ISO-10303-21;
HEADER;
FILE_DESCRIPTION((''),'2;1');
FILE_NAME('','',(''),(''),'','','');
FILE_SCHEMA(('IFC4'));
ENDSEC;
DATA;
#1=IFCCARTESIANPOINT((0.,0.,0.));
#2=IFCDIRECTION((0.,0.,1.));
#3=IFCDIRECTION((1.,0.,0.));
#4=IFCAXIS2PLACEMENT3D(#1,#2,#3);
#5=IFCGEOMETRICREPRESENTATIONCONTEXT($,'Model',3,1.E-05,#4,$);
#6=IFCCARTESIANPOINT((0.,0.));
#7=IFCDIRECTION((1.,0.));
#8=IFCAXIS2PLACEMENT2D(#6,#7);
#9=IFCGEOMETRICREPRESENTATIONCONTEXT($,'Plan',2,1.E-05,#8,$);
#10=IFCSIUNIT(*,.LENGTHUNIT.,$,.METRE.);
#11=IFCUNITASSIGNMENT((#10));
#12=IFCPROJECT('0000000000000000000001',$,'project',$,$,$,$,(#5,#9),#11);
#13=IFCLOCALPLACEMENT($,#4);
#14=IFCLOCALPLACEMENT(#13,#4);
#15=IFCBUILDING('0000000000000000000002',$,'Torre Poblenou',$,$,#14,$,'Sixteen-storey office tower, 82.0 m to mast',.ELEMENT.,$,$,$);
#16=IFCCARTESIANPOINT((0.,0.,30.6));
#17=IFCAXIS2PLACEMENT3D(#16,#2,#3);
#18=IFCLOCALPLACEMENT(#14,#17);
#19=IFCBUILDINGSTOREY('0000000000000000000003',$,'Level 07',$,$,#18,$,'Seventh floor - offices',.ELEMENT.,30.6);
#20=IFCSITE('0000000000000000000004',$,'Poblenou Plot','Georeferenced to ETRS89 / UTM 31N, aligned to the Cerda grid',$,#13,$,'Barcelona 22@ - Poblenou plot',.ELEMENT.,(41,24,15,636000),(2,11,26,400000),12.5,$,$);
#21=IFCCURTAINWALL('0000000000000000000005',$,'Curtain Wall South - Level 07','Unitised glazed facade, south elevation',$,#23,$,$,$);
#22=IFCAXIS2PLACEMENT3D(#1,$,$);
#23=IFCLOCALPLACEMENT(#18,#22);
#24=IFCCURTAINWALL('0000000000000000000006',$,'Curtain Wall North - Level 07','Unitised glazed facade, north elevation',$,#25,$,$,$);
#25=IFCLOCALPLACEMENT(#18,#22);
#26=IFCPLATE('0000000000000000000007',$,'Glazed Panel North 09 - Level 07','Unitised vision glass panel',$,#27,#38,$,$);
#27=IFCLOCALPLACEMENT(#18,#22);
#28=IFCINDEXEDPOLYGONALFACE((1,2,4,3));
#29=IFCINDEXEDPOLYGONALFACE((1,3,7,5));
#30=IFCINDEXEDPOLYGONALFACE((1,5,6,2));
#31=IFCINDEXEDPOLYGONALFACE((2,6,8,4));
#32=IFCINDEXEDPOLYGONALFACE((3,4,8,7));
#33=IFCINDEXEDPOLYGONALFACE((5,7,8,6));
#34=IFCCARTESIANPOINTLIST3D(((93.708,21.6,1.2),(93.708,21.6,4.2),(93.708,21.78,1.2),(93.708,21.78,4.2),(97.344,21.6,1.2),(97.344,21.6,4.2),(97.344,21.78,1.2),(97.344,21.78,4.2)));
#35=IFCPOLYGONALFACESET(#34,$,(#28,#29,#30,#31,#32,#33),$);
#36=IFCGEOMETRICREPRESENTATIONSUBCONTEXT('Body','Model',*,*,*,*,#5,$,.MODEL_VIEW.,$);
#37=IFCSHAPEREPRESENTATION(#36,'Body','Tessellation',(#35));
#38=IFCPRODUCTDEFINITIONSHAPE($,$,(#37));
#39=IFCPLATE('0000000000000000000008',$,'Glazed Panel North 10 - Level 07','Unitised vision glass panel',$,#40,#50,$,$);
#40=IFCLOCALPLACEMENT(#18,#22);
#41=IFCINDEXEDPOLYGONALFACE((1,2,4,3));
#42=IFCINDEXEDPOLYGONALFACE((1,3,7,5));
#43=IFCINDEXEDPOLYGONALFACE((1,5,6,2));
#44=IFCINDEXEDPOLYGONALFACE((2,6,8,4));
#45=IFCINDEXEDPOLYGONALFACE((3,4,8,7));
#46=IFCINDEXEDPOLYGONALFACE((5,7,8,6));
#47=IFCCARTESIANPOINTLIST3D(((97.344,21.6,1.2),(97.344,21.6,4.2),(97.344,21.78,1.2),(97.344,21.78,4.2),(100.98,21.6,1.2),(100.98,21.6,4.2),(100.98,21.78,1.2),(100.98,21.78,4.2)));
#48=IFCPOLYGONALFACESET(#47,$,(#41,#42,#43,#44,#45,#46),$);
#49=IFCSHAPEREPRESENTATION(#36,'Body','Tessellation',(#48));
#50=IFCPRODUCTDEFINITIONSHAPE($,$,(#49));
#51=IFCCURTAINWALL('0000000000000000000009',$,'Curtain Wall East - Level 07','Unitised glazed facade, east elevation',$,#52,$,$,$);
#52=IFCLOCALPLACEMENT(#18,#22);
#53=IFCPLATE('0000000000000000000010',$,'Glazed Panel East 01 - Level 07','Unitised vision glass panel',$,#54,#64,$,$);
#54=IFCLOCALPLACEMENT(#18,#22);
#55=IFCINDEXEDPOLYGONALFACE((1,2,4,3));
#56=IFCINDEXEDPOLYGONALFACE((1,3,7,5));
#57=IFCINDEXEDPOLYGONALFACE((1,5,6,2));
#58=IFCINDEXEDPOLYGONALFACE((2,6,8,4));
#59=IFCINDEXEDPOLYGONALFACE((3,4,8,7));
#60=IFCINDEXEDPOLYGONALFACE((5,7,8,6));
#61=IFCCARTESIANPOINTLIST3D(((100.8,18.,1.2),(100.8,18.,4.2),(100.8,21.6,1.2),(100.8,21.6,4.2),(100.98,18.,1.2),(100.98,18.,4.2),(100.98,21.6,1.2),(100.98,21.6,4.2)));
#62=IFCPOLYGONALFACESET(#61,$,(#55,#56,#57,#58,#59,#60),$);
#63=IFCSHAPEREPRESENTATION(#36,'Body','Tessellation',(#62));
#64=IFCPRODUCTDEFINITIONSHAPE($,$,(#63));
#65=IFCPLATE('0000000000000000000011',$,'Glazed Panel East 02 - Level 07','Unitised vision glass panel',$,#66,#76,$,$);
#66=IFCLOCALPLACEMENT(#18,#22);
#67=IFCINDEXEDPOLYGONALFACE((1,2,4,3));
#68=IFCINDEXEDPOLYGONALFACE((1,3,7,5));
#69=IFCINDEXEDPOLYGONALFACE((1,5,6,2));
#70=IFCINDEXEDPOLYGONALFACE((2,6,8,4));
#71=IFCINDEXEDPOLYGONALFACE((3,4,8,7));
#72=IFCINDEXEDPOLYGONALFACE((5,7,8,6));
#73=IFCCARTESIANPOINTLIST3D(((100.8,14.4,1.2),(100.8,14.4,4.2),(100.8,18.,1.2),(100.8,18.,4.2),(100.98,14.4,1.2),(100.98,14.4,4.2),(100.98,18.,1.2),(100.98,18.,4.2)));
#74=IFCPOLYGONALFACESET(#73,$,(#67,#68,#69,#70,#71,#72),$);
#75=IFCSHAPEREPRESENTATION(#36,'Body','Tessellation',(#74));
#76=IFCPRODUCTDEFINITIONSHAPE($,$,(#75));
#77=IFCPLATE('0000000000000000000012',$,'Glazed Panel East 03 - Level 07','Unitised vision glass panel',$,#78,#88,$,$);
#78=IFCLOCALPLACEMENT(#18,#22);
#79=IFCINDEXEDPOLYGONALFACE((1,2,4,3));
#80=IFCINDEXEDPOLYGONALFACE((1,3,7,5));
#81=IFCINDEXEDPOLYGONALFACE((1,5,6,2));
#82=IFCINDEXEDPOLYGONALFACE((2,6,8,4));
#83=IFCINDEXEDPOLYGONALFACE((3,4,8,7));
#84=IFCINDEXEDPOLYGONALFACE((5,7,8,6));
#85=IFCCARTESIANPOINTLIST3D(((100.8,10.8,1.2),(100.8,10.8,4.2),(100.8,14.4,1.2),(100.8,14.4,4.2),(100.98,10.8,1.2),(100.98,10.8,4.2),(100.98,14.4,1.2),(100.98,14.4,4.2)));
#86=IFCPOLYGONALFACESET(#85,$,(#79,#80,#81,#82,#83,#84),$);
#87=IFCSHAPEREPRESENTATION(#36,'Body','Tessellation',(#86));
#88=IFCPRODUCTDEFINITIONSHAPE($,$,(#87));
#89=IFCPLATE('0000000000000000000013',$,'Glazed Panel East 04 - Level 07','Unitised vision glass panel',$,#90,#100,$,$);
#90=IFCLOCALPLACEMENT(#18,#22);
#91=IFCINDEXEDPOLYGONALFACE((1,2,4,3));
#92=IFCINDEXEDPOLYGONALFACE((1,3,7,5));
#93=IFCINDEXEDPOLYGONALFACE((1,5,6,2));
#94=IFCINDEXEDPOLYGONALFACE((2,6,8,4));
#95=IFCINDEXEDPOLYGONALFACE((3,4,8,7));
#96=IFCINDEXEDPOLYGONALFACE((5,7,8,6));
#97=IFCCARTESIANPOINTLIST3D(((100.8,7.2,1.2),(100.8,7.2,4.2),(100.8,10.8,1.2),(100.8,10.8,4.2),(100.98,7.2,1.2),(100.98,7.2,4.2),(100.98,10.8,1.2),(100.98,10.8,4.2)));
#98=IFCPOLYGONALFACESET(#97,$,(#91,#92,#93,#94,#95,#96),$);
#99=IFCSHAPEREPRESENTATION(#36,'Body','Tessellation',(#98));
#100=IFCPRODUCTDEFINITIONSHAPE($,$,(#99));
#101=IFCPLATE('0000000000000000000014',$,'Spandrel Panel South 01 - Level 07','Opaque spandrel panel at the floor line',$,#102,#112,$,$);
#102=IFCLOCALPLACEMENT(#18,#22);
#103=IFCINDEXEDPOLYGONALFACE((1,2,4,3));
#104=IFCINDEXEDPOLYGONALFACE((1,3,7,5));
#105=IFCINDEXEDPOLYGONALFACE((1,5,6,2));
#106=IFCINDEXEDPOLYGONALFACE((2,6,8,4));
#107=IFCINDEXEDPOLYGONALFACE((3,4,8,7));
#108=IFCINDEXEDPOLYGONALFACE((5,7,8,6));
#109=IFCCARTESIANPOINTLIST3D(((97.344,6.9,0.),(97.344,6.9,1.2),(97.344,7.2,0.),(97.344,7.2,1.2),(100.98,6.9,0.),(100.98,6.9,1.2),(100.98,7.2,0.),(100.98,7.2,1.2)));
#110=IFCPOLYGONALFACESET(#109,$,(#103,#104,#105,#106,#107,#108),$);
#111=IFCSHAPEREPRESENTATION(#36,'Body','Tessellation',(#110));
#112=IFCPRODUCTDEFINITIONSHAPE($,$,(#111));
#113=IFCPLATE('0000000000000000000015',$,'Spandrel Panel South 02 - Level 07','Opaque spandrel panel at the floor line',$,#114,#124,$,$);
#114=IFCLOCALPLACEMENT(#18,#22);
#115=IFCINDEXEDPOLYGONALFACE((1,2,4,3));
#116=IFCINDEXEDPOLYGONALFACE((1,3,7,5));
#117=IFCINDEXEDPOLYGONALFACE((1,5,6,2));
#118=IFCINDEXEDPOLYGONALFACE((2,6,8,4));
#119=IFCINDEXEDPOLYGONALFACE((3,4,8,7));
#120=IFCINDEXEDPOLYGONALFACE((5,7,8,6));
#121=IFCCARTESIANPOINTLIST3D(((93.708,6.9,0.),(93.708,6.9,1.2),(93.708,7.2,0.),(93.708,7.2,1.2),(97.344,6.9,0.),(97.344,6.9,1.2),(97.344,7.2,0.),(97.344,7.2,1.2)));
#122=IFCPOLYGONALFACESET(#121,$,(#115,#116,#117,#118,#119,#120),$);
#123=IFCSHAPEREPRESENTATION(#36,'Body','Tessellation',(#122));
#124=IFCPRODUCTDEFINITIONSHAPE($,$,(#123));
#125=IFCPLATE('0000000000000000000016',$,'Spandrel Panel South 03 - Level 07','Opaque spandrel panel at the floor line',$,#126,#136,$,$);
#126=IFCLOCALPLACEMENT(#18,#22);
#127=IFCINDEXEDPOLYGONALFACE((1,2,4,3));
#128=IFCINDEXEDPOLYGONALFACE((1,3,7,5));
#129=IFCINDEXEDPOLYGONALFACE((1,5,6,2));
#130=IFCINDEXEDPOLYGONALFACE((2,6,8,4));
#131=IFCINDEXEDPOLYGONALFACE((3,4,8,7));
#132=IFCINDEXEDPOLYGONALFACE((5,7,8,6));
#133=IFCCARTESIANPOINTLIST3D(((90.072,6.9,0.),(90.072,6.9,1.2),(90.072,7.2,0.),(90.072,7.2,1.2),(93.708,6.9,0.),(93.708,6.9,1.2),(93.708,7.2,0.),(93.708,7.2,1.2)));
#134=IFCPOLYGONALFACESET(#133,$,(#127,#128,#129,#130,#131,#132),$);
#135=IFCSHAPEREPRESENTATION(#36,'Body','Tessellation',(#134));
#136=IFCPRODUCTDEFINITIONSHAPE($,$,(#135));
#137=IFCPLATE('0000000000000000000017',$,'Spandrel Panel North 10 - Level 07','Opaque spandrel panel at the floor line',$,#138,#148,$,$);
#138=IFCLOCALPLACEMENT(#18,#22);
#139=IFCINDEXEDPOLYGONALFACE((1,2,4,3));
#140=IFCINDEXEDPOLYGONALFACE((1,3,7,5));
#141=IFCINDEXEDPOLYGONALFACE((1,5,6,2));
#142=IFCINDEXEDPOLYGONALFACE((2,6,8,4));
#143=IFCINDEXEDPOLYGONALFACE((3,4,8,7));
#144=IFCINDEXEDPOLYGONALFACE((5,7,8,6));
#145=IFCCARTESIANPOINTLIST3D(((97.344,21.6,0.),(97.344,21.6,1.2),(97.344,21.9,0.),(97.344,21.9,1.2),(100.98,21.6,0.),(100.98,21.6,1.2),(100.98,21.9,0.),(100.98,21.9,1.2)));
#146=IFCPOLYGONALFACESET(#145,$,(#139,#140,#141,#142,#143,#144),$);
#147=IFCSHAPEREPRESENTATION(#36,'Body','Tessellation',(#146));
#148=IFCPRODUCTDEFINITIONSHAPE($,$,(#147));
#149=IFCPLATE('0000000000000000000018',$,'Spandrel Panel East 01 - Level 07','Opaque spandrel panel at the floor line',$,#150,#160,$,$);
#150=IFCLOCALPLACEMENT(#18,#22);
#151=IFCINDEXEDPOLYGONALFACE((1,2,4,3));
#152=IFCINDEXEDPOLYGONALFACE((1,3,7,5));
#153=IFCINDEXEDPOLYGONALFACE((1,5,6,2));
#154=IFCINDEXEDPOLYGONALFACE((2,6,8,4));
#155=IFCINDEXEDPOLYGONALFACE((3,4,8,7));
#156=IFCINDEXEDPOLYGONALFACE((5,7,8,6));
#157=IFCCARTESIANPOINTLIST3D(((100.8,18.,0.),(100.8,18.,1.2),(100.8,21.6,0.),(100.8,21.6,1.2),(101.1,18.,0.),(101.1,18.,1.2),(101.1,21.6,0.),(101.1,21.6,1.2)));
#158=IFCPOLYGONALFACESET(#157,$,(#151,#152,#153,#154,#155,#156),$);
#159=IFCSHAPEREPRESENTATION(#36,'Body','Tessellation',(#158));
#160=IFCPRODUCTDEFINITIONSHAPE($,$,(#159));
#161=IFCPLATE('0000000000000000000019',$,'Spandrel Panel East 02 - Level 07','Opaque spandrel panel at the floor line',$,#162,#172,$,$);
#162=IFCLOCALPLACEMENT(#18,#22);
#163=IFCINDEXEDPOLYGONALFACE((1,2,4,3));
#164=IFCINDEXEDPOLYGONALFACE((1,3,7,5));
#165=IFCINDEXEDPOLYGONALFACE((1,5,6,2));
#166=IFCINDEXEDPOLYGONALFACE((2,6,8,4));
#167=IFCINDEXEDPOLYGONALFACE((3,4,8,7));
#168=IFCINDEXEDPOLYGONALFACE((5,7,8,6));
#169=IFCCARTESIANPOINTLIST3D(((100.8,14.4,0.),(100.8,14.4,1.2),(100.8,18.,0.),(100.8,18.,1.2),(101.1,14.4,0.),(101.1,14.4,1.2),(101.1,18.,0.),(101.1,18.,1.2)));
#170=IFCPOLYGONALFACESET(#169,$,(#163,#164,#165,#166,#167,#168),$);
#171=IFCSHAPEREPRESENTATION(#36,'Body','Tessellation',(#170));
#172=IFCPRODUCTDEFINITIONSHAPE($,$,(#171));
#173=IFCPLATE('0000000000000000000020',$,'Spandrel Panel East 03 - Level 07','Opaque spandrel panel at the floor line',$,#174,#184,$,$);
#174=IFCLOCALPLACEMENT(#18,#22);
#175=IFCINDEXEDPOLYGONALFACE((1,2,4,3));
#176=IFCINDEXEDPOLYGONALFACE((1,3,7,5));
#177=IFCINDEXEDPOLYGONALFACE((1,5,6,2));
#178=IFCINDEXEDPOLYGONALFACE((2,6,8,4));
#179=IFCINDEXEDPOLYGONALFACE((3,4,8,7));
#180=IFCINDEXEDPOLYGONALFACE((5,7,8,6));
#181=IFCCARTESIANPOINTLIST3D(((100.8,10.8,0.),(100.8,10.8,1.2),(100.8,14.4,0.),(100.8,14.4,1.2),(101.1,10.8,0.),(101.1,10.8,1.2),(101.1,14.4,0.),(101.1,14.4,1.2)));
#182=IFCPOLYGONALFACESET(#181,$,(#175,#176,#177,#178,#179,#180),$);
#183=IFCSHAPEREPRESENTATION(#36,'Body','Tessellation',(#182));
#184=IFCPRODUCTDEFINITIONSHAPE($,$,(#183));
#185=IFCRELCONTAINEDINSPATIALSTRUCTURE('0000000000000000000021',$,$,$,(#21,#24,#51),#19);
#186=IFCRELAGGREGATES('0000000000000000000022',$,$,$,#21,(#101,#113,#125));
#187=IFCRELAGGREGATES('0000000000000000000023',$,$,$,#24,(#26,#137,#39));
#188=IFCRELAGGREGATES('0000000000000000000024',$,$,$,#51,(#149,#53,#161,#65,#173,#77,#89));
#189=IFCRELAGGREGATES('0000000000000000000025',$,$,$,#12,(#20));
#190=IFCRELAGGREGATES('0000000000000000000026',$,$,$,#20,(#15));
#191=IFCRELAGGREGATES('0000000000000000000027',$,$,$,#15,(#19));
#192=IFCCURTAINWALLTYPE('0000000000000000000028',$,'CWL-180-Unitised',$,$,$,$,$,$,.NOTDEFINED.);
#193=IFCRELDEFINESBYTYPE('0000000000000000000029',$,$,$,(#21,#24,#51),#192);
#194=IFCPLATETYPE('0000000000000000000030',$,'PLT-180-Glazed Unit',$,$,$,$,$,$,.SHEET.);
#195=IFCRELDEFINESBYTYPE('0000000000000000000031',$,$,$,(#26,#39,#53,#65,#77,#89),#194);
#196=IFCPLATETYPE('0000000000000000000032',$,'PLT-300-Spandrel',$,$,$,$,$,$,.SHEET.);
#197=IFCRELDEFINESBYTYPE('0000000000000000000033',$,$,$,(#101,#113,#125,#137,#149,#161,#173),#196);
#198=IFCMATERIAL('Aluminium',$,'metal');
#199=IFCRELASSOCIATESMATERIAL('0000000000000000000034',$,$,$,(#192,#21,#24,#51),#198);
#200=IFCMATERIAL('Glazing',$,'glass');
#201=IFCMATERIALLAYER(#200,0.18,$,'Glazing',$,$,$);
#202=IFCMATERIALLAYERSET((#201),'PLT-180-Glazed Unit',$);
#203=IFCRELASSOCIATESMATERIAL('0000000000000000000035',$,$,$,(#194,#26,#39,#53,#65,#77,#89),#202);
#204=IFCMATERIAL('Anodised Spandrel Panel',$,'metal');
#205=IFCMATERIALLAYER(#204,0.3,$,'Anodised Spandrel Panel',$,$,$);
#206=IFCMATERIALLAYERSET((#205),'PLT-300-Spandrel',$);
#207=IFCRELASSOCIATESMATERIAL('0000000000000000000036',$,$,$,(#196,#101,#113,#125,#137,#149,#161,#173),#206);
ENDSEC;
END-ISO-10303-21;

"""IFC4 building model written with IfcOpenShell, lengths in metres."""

from ifc_helpers import new_model, si_unit, frame, origin_with_axes, origin_2d_with_axis, place, context, subcontext, project, spatial, line, indexed_curve, outline, extrude, material, layer, layer_set, layer_usage, type_object, element, aggregate, save


model = new_model("IFC4")

# Units and contexts
model_context = context("Model", 3, precision=1e-05, world=origin_with_axes())
plan_context = context("Plan", 2, precision=1e-05, world=origin_2d_with_axis())
body_context = subcontext(model_context, "Body", "Model", "MODEL_VIEW")
ifc_project = project(units=[si_unit("LENGTHUNIT", "METRE")], contexts=[model_context, plan_context])

# Site, building, storey
site_placement = place(None, origin_with_axes())
site = spatial("IfcSite", under=ifc_project, at=site_placement, Name="Poblenou Plot", Description="Georeferenced to ETRS89 / UTM 31N, aligned to the Cerda grid", LongName="Barcelona 22@ - Poblenou plot", CompositionType="ELEMENT", RefLatitude=(41, 24, 15, 636000), RefLongitude=(2, 11, 26, 400000), RefElevation=12.5)
building_placement = place(site_placement, origin_with_axes())
building = spatial("IfcBuilding", under=site, at=building_placement, Name="Torre Poblenou", LongName="Sixteen-storey office tower, 82.0 m to mast", CompositionType="ELEMENT")
storey_placement = place(building_placement, frame((0.0, 0.0, 30.6), z_axis=(0.0, 0.0, 1.0), x_axis=(1.0, 0.0, 0.0)))
storey = spatial("IfcBuildingStorey", under=building, at=storey_placement, Name="Level 07", LongName="Seventh floor - offices", CompositionType="ELEMENT", Elevation=30.6)

# Curtain walls, plates
ifc_material_1 = material(Name="Aluminium", Category="metal")
curtain_wall_type = type_object("IfcCurtainWallType", Name="CWL-180-Unitised", PredefinedType="NOTDEFINED", material=ifc_material_1)
curtain_wall_1_placement = place(storey_placement, frame((100.98, 7.2, 0.0), z_axis=(0.0, 0.0, 1.0), x_axis=(-1.0, 0.0, 0.0)))
curtain_wall_1 = element("IfcCurtainWall", 1, at=curtain_wall_1_placement, inside=storey, type_object=curtain_wall_type, material=ifc_material_1, Name="Curtain Wall South - Level 07", Description="Unitised glazed facade, south elevation")
ifc_material_2 = material(Name="Glazing", Category="glass")
ifc_layer_1 = layer(ifc_material_2, 0.18, Name="Glazing")
ifc_layer_set_1 = layer_set([ifc_layer_1], Name="PLT-180-Glazed Unit")
plate_type_1 = type_object("IfcPlateType", Name="PLT-180-Glazed Unit", PredefinedType="SHEET", material=ifc_layer_set_1)
curtain_wall_2_placement = place(storey_placement, frame((64.62, 21.6, 0.0), z_axis=(0.0, 0.0, 1.0), x_axis=(1.0, 0.0, 0.0)))
curtain_wall_2 = element("IfcCurtainWall", 2, at=curtain_wall_2_placement, inside=storey, type_object=curtain_wall_type, material=ifc_material_1, Name="Curtain Wall North - Level 07", Description="Unitised glazed facade, north elevation")
ifc_layer_usage_1 = layer_usage(ifc_layer_set_1, "AXIS2", "POSITIVE", 0.0)
plate_1_placement = place(curtain_wall_2_placement, frame((29.088, 0.0, 1.2), z_axis=(0.0, 0.0, 1.0), x_axis=(1.0, 0.0, 0.0)))
plate_1 = element("IfcPlate", 3, at=plate_1_placement, type_object=plate_type_1, material=ifc_layer_usage_1, Name="Glazed Panel North 09 - Level 07", Description="Unitised vision glass panel", context=body_context, shape_type="SweptSolid", body=[
    extrude(outline(indexed_curve([(0.0, 0.0), (3.636, 0.0), (3.636, 0.18), (0.0, 0.18)], segments=[line(1, 2, 3, 4, 1)])), origin_with_axes(), (0.0, 0.0, 1.0), 3.0),
])
ifc_layer_usage_2 = layer_usage(ifc_layer_set_1, "AXIS2", "POSITIVE", 0.0)
plate_2_placement = place(curtain_wall_2_placement, frame((32.724, 0.0, 1.2), z_axis=(0.0, 0.0, 1.0), x_axis=(1.0, 0.0, 0.0)))
plate_2 = element("IfcPlate", 4, at=plate_2_placement, type_object=plate_type_1, material=ifc_layer_usage_2, Name="Glazed Panel North 10 - Level 07", Description="Unitised vision glass panel", context=body_context, shape_type="SweptSolid", body=[
    extrude(outline(indexed_curve([(0.0, 0.0), (3.636, 0.0), (3.636, 0.18), (0.0, 0.18)], segments=[line(1, 2, 3, 4, 1)])), origin_with_axes(), (0.0, 0.0, 1.0), 3.0),
])
curtain_wall_3_placement = place(storey_placement, frame((100.8, 21.6, 0.0), z_axis=(0.0, 0.0, 1.0), x_axis=(0.0, -1.0, 0.0)))
curtain_wall_3 = element("IfcCurtainWall", 5, at=curtain_wall_3_placement, inside=storey, type_object=curtain_wall_type, material=ifc_material_1, Name="Curtain Wall East - Level 07", Description="Unitised glazed facade, east elevation")
ifc_layer_usage_3 = layer_usage(ifc_layer_set_1, "AXIS2", "POSITIVE", 0.0)
plate_3_placement = place(curtain_wall_3_placement, frame((0.0, 0.0, 1.2), z_axis=(0.0, 0.0, 1.0), x_axis=(1.0, 0.0, 0.0)))
plate_3 = element("IfcPlate", 6, at=plate_3_placement, type_object=plate_type_1, material=ifc_layer_usage_3, Name="Glazed Panel East 01 - Level 07", Description="Unitised vision glass panel", context=body_context, shape_type="SweptSolid", body=[
    extrude(outline(indexed_curve([(0.0, 0.0), (3.6, 0.0), (3.6, 0.18), (0.0, 0.18)], segments=[line(1, 2, 3, 4, 1)])), origin_with_axes(), (0.0, 0.0, 1.0), 3.0),
])
ifc_layer_usage_4 = layer_usage(ifc_layer_set_1, "AXIS2", "POSITIVE", 0.0)
plate_4_placement = place(curtain_wall_3_placement, frame((3.6, 0.0, 1.2), z_axis=(0.0, 0.0, 1.0), x_axis=(1.0, 0.0, 0.0)))
plate_4 = element("IfcPlate", 7, at=plate_4_placement, type_object=plate_type_1, material=ifc_layer_usage_4, Name="Glazed Panel East 02 - Level 07", Description="Unitised vision glass panel", context=body_context, shape_type="SweptSolid", body=[
    extrude(outline(indexed_curve([(0.0, 0.0), (3.6, 0.0), (3.6, 0.18), (0.0, 0.18)], segments=[line(1, 2, 3, 4, 1)])), origin_with_axes(), (0.0, 0.0, 1.0), 3.0),
])
ifc_layer_usage_5 = layer_usage(ifc_layer_set_1, "AXIS2", "POSITIVE", 0.0)
plate_5_placement = place(curtain_wall_3_placement, frame((7.2, 0.0, 1.2), z_axis=(0.0, 0.0, 1.0), x_axis=(1.0, 0.0, 0.0)))
plate_5 = element("IfcPlate", 8, at=plate_5_placement, type_object=plate_type_1, material=ifc_layer_usage_5, Name="Glazed Panel East 03 - Level 07", Description="Unitised vision glass panel", context=body_context, shape_type="SweptSolid", body=[
    extrude(outline(indexed_curve([(0.0, 0.0), (3.6, 0.0), (3.6, 0.18), (0.0, 0.18)], segments=[line(1, 2, 3, 4, 1)])), origin_with_axes(), (0.0, 0.0, 1.0), 3.0),
])
ifc_layer_usage_6 = layer_usage(ifc_layer_set_1, "AXIS2", "POSITIVE", 0.0)
plate_6_placement = place(curtain_wall_3_placement, frame((10.8, 0.0, 1.2), z_axis=(0.0, 0.0, 1.0), x_axis=(1.0, 0.0, 0.0)))
plate_6 = element("IfcPlate", 9, at=plate_6_placement, type_object=plate_type_1, material=ifc_layer_usage_6, Name="Glazed Panel East 04 - Level 07", Description="Unitised vision glass panel", context=body_context, shape_type="SweptSolid", body=[
    extrude(outline(indexed_curve([(0.0, 0.0), (3.6, 0.0), (3.6, 0.18), (0.0, 0.18)], segments=[line(1, 2, 3, 4, 1)])), origin_with_axes(), (0.0, 0.0, 1.0), 3.0),
])

# Plates
ifc_material_3 = material(Name="Anodised Spandrel Panel", Category="metal")
ifc_layer_2 = layer(ifc_material_3, 0.3, Name="Anodised Spandrel Panel")
ifc_layer_set_2 = layer_set([ifc_layer_2], Name="PLT-300-Spandrel")
ifc_layer_usage_7 = layer_usage(ifc_layer_set_2, "AXIS2", "POSITIVE", 0.0)
plate_type_2 = type_object("IfcPlateType", Name="PLT-300-Spandrel", PredefinedType="SHEET", material=ifc_layer_set_2)
plate_7_placement = place(curtain_wall_1_placement, origin_with_axes())
plate_7 = element("IfcPlate", 10, at=plate_7_placement, type_object=plate_type_2, material=ifc_layer_usage_7, Name="Spandrel Panel South 01 - Level 07", Description="Opaque spandrel panel at the floor line", context=body_context, shape_type="SweptSolid", body=[
    extrude(outline(indexed_curve([(0.0, 0.0), (3.636, 0.0), (3.636, 0.3), (0.0, 0.3)], segments=[line(1, 2, 3, 4, 1)])), origin_with_axes(), (0.0, 0.0, 1.0), 1.2),
])
ifc_layer_usage_8 = layer_usage(ifc_layer_set_2, "AXIS2", "POSITIVE", 0.0)
plate_8_placement = place(curtain_wall_1_placement, frame((3.636, 0.0, 0.0), z_axis=(0.0, 0.0, 1.0), x_axis=(1.0, 0.0, 0.0)))
plate_8 = element("IfcPlate", 11, at=plate_8_placement, type_object=plate_type_2, material=ifc_layer_usage_8, Name="Spandrel Panel South 02 - Level 07", Description="Opaque spandrel panel at the floor line", context=body_context, shape_type="SweptSolid", body=[
    extrude(outline(indexed_curve([(0.0, 0.0), (3.636, 0.0), (3.636, 0.3), (0.0, 0.3)], segments=[line(1, 2, 3, 4, 1)])), origin_with_axes(), (0.0, 0.0, 1.0), 1.2),
])
ifc_layer_usage_9 = layer_usage(ifc_layer_set_2, "AXIS2", "POSITIVE", 0.0)
plate_9_placement = place(curtain_wall_1_placement, frame((7.272, 0.0, 0.0), z_axis=(0.0, 0.0, 1.0), x_axis=(1.0, 0.0, 0.0)))
plate_9 = element("IfcPlate", 12, at=plate_9_placement, type_object=plate_type_2, material=ifc_layer_usage_9, Name="Spandrel Panel South 03 - Level 07", Description="Opaque spandrel panel at the floor line", context=body_context, shape_type="SweptSolid", body=[
    extrude(outline(indexed_curve([(0.0, 0.0), (3.636, 0.0), (3.636, 0.3), (0.0, 0.3)], segments=[line(1, 2, 3, 4, 1)])), origin_with_axes(), (0.0, 0.0, 1.0), 1.2),
])
aggregate(curtain_wall_1, [plate_7, plate_8, plate_9])
ifc_layer_usage_10 = layer_usage(ifc_layer_set_2, "AXIS2", "POSITIVE", 0.0)
plate_10_placement = place(curtain_wall_2_placement, frame((32.724, 0.0, 0.0), z_axis=(0.0, 0.0, 1.0), x_axis=(1.0, 0.0, 0.0)))
plate_10 = element("IfcPlate", 13, at=plate_10_placement, type_object=plate_type_2, material=ifc_layer_usage_10, Name="Spandrel Panel North 10 - Level 07", Description="Opaque spandrel panel at the floor line", context=body_context, shape_type="SweptSolid", body=[
    extrude(outline(indexed_curve([(0.0, 0.0), (3.636, 0.0), (3.636, 0.3), (0.0, 0.3)], segments=[line(1, 2, 3, 4, 1)])), origin_with_axes(), (0.0, 0.0, 1.0), 1.2),
])
aggregate(curtain_wall_2, [plate_1, plate_10, plate_2])
ifc_layer_usage_11 = layer_usage(ifc_layer_set_2, "AXIS2", "POSITIVE", 0.0)
plate_11_placement = place(curtain_wall_3_placement, origin_with_axes())
plate_11 = element("IfcPlate", 14, at=plate_11_placement, type_object=plate_type_2, material=ifc_layer_usage_11, Name="Spandrel Panel East 01 - Level 07", Description="Opaque spandrel panel at the floor line", context=body_context, shape_type="SweptSolid", body=[
    extrude(outline(indexed_curve([(0.0, 0.0), (3.6, 0.0), (3.6, 0.3), (0.0, 0.3)], segments=[line(1, 2, 3, 4, 1)])), origin_with_axes(), (0.0, 0.0, 1.0), 1.2),
])
ifc_layer_usage_12 = layer_usage(ifc_layer_set_2, "AXIS2", "POSITIVE", 0.0)
plate_12_placement = place(curtain_wall_3_placement, frame((3.6, 0.0, 0.0), z_axis=(0.0, 0.0, 1.0), x_axis=(1.0, 0.0, 0.0)))
plate_12 = element("IfcPlate", 15, at=plate_12_placement, type_object=plate_type_2, material=ifc_layer_usage_12, Name="Spandrel Panel East 02 - Level 07", Description="Opaque spandrel panel at the floor line", context=body_context, shape_type="SweptSolid", body=[
    extrude(outline(indexed_curve([(0.0, 0.0), (3.6, 0.0), (3.6, 0.3), (0.0, 0.3)], segments=[line(1, 2, 3, 4, 1)])), origin_with_axes(), (0.0, 0.0, 1.0), 1.2),
])
ifc_layer_usage_13 = layer_usage(ifc_layer_set_2, "AXIS2", "POSITIVE", 0.0)
plate_13_placement = place(curtain_wall_3_placement, frame((7.2, 0.0, 0.0), z_axis=(0.0, 0.0, 1.0), x_axis=(1.0, 0.0, 0.0)))
plate_13 = element("IfcPlate", 16, at=plate_13_placement, type_object=plate_type_2, material=ifc_layer_usage_13, Name="Spandrel Panel East 03 - Level 07", Description="Opaque spandrel panel at the floor line", context=body_context, shape_type="SweptSolid", body=[
    extrude(outline(indexed_curve([(0.0, 0.0), (3.6, 0.0), (3.6, 0.3), (0.0, 0.3)], segments=[line(1, 2, 3, 4, 1)])), origin_with_axes(), (0.0, 0.0, 1.0), 1.2),
])
aggregate(curtain_wall_3, [plate_11, plate_3, plate_12, plate_4, plate_13, plate_5, plate_6])

save(model, "model.ifc")
